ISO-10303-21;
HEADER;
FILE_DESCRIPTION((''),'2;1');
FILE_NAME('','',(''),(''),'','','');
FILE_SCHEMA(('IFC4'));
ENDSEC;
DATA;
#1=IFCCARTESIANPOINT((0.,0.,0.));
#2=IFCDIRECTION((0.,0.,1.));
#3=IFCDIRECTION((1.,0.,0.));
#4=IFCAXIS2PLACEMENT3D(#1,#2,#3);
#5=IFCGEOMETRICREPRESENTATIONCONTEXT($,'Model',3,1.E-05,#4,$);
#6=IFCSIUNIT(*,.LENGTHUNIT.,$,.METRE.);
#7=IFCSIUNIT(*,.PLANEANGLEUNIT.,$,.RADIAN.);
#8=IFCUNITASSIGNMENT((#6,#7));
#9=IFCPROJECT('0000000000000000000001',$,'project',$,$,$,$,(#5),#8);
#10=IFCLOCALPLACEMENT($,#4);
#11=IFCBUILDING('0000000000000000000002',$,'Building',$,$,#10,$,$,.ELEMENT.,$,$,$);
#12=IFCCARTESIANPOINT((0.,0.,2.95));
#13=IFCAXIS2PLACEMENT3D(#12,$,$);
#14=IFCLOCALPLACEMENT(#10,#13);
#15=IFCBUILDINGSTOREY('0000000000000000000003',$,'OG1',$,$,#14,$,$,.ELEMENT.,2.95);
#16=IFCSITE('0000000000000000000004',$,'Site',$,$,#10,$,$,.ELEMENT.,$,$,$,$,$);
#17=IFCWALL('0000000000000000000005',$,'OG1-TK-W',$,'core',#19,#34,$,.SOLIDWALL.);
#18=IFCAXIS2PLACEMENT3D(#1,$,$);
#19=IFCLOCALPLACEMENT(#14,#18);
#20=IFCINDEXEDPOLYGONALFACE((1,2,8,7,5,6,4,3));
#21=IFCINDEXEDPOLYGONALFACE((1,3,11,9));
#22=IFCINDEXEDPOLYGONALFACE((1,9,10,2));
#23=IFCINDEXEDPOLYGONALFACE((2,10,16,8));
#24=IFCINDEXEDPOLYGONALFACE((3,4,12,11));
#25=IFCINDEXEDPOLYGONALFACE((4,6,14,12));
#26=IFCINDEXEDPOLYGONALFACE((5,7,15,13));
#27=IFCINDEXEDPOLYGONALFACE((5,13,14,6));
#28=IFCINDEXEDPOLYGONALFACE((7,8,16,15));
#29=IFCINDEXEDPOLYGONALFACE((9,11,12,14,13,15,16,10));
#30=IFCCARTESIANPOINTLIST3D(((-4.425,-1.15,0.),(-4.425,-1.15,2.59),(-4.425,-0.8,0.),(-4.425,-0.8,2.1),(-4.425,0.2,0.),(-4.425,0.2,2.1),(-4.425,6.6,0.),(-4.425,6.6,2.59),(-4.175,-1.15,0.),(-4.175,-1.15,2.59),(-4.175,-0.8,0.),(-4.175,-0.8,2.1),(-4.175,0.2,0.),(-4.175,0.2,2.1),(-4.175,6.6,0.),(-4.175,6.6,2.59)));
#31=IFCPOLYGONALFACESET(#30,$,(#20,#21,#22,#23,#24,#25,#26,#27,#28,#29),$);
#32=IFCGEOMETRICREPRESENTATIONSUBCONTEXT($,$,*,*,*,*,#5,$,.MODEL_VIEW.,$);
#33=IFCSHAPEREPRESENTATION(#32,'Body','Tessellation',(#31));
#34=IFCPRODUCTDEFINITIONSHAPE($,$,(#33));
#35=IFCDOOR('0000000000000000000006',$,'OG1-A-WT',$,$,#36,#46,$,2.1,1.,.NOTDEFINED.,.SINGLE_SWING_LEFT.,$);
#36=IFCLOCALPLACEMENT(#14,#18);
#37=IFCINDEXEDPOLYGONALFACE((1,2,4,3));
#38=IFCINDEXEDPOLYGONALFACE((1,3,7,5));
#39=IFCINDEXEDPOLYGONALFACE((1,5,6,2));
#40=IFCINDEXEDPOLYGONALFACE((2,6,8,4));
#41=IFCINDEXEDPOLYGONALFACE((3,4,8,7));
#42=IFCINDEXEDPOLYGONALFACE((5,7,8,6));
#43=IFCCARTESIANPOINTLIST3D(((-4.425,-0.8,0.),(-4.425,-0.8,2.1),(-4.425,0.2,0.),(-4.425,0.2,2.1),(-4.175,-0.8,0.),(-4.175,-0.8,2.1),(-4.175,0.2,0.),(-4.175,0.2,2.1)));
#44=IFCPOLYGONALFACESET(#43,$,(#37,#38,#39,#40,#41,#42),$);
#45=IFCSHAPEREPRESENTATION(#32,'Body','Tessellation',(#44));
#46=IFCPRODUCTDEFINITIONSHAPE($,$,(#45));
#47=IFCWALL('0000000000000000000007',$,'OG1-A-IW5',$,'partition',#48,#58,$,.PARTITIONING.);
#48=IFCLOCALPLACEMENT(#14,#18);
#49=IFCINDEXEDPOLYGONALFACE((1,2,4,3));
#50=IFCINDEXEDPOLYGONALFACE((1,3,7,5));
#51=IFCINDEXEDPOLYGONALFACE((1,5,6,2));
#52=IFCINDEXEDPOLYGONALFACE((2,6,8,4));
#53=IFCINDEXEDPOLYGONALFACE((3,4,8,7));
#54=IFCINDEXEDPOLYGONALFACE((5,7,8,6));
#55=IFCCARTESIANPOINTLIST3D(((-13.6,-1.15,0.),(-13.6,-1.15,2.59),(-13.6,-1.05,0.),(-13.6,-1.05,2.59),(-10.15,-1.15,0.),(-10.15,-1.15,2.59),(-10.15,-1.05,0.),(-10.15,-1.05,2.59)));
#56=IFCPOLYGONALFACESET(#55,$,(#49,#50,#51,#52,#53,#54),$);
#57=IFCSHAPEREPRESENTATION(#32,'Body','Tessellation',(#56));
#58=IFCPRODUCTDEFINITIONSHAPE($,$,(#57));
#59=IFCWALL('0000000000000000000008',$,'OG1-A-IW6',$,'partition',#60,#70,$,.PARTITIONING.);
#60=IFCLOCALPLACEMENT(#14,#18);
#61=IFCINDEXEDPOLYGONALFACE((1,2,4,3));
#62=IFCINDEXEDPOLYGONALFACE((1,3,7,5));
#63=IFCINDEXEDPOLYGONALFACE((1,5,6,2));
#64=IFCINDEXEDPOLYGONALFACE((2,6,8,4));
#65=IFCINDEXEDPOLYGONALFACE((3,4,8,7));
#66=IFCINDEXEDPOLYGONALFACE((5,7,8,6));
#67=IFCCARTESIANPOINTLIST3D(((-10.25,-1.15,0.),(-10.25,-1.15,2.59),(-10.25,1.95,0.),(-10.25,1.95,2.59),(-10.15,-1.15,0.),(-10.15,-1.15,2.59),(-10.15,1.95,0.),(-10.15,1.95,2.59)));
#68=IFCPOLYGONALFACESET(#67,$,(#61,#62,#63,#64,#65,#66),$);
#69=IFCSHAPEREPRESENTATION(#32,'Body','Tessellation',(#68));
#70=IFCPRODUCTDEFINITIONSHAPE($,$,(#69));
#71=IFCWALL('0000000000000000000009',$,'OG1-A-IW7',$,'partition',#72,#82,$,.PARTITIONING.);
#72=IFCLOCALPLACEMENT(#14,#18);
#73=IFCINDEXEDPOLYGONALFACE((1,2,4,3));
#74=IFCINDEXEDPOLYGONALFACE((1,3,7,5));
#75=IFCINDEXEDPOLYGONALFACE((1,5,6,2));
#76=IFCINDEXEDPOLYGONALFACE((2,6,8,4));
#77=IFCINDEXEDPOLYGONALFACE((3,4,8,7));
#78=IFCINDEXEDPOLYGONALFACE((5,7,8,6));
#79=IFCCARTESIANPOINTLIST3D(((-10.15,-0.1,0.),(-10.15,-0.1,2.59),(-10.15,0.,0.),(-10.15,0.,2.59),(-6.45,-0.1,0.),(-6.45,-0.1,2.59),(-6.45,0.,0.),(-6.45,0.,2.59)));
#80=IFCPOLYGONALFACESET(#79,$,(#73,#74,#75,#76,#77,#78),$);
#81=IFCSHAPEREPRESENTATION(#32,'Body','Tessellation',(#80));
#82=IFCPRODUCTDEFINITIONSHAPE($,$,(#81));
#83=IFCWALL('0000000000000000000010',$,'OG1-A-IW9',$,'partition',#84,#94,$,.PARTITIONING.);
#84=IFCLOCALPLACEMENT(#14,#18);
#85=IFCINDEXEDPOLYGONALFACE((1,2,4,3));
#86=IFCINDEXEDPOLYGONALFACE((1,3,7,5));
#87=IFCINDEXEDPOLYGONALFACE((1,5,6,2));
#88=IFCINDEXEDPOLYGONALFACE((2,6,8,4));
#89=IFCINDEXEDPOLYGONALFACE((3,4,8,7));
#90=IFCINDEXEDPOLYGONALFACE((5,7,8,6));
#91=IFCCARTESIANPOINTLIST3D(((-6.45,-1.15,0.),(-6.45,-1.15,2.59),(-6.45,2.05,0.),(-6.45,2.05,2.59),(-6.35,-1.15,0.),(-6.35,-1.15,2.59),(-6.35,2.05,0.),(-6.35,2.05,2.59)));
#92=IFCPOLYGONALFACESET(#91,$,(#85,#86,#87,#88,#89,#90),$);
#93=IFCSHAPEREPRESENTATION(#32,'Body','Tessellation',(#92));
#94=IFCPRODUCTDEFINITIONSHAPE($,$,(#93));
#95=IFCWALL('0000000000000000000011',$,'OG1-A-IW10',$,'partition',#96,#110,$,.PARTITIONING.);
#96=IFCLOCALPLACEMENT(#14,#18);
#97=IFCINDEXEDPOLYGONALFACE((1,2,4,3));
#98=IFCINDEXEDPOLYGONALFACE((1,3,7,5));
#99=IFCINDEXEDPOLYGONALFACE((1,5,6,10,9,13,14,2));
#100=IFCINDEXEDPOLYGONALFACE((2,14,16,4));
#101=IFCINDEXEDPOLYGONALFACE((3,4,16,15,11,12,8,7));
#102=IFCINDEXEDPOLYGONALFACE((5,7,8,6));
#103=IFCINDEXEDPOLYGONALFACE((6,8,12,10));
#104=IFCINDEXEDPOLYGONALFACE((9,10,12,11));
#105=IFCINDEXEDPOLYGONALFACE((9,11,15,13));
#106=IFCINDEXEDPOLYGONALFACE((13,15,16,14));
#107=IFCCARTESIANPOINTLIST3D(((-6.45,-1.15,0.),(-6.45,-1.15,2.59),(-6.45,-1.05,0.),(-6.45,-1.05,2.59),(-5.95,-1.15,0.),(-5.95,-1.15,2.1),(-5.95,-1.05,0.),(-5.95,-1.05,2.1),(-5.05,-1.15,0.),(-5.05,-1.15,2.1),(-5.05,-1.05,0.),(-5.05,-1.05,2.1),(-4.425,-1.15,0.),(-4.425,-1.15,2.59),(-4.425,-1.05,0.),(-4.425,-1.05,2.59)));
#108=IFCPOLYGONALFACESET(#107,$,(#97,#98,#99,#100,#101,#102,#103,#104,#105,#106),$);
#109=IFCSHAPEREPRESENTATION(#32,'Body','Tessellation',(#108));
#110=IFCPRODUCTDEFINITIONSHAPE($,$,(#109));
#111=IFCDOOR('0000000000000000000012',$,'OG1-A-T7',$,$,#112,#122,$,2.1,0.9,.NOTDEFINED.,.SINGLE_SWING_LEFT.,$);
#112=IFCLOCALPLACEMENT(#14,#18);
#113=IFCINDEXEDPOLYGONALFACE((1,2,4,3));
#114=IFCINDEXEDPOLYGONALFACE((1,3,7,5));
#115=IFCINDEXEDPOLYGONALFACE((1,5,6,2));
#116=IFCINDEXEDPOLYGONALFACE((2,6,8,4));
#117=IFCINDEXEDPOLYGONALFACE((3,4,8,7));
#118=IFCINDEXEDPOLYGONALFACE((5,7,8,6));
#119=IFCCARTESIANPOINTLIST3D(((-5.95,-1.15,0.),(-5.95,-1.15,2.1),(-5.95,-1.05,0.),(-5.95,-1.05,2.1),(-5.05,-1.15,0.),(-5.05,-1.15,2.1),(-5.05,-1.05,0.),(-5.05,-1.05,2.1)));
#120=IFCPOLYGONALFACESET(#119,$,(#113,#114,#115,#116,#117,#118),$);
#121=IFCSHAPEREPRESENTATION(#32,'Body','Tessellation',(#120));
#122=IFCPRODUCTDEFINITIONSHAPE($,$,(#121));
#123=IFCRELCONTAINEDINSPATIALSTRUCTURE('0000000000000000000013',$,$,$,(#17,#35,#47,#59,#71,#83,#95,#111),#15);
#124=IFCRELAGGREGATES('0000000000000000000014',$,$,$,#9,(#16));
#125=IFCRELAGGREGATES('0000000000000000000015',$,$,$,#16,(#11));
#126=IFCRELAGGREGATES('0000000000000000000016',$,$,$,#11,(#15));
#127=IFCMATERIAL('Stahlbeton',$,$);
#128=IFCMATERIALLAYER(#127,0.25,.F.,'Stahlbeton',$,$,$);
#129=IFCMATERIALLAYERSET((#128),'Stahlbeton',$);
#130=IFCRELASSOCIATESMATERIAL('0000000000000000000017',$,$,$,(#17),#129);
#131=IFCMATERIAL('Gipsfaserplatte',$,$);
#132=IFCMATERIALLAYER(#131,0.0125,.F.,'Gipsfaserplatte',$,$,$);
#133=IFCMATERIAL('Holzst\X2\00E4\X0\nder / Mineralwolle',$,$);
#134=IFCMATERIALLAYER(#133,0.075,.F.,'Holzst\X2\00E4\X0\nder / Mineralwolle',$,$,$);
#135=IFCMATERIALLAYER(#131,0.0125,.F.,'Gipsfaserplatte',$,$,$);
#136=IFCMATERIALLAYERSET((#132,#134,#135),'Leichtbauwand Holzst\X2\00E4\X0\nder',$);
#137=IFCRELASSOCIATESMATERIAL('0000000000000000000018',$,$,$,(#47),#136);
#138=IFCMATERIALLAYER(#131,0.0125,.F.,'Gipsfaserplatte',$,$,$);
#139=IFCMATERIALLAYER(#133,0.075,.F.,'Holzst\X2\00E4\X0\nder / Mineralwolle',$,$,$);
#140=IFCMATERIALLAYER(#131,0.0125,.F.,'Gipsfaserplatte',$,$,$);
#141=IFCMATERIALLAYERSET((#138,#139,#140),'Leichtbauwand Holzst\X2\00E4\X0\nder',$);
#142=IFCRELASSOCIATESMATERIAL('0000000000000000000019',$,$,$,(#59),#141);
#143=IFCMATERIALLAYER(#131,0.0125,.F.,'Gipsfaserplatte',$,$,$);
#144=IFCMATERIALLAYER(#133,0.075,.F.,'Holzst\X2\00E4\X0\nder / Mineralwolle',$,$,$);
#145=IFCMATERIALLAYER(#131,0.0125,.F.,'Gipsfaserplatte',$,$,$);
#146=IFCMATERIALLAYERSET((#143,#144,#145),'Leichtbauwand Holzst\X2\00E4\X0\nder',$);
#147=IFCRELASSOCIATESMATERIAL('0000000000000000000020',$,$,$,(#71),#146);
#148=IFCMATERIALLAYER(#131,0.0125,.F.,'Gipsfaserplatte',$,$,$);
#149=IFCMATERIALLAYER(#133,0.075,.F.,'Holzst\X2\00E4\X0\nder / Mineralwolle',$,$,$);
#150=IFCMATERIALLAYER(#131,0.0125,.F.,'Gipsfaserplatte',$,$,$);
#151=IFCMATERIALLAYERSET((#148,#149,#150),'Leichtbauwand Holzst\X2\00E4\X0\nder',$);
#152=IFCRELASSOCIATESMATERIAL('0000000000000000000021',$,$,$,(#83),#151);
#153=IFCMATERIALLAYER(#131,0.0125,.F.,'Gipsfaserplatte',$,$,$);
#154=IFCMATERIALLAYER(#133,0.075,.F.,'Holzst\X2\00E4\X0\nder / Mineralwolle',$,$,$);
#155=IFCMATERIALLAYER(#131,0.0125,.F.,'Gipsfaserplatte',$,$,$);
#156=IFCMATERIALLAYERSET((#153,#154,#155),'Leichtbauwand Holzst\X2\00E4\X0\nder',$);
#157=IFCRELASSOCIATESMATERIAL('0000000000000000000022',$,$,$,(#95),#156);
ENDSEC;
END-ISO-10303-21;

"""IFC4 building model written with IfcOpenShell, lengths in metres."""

from ifc_helpers import new_model, si_unit, frame, frame_2d, origin, origin_with_axes, place, context, subcontext, project, spatial, rectangle, extrude, material, layer, layer_set, element, fill, save


model = new_model("IFC4")

# Units and contexts
model_context = context("Model", 3, precision=1e-05, world=origin_with_axes())
sub_context = subcontext(model_context, None, None, "MODEL_VIEW")
ifc_project = project(units=[si_unit("LENGTHUNIT", "METRE"), si_unit("PLANEANGLEUNIT", "RADIAN")], contexts=[model_context])

# Site, building, storey
placement = place(None, origin_with_axes())
site = spatial("IfcSite", under=ifc_project, at=placement, Name="Site", CompositionType="ELEMENT")
building = spatial("IfcBuilding", under=site, at=placement, Name="Building", CompositionType="ELEMENT")
storey_placement = place(placement, frame((0.0, 0.0, 2.95)))
storey = spatial("IfcBuildingStorey", under=building, at=storey_placement, Name="OG1", CompositionType="ELEMENT", Elevation=2.95)

# Shared definitions
ifc_material_1 = material(Name="Gipsfaserplatte")

# Wall, opening, door
ifc_material_2 = material(Name="Stahlbeton")
ifc_layer_1 = layer(ifc_material_2, 0.25, ventilated=False, Name="Stahlbeton")
ifc_layer_set_1 = layer_set([ifc_layer_1], Name="Stahlbeton")
wall_1_placement = place(storey_placement, frame((-4.3, -1.15, 0.0), z_axis=(0.0, 0.0, 1.0), x_axis=(0.0, 1.0, 0.0)))
wall_1 = element("IfcWall", 1, at=wall_1_placement, inside=storey, material=ifc_layer_set_1, Name="OG1-TK-W", ObjectType="core", PredefinedType="SOLIDWALL", context=sub_context, shape_type="SweptSolid", body=[
    extrude(rectangle(XDim=7.75, YDim=0.25, at=frame_2d((3.875, 0.0))), origin(), (0.0, 0.0, 1.0), 2.59),
])
opening_1_placement = place(wall_1_placement, frame((0.85, 0.175, 0.0), z_axis=(0.0, -1.0, 0.0), x_axis=(1.0, 0.0, 0.0)))
opening_1 = element("IfcOpeningElement", 2, at=opening_1_placement, cuts=wall_1, PredefinedType="OPENING", context=sub_context, shape_type="SweptSolid", body=[
    extrude(rectangle(XDim=1.0, YDim=2.1, at=frame_2d((0.0, 1.05))), origin(), (0.0, 0.0, 1.0), 0.35),
])
door_1_placement = place(wall_1_placement, frame((0.85, 0.125, 0.0), z_axis=(0.0, -1.0, 0.0), x_axis=(1.0, 0.0, 0.0)))
door_1 = element("IfcDoor", 3, at=door_1_placement, inside=storey, Name="OG1-A-WT", OperationType="SINGLE_SWING_LEFT", OverallHeight=2.1, OverallWidth=1.0, PredefinedType="NOTDEFINED", context=sub_context, shape_type="SweptSolid", body=[
    extrude(rectangle(XDim=1.0, YDim=2.1, at=frame_2d((0.0, 1.05))), origin(), (0.0, 0.0, 1.0), 0.25),
])
fill(opening_1, door_1)

# Walls
ifc_layer_2 = layer(ifc_material_1, 0.0125, ventilated=False, Name="Gipsfaserplatte")
ifc_material_3 = material(Name="Holzständer / Mineralwolle")
ifc_layer_3 = layer(ifc_material_3, 0.075, ventilated=False, Name="Holzständer / Mineralwolle")
ifc_layer_4 = layer(ifc_material_1, 0.0125, ventilated=False, Name="Gipsfaserplatte")
ifc_layer_set_2 = layer_set([ifc_layer_2, ifc_layer_3, ifc_layer_4], Name="Leichtbauwand Holzständer")
wall_2_placement = place(storey_placement, frame((-13.6, -1.1, 0.0), z_axis=(0.0, 0.0, 1.0), x_axis=(1.0, 0.0, 0.0)))
element("IfcWall", 4, at=wall_2_placement, inside=storey, material=ifc_layer_set_2, Name="OG1-A-IW5", ObjectType="partition", PredefinedType="PARTITIONING", context=sub_context, shape_type="SweptSolid", body=[
    extrude(rectangle(XDim=3.45, YDim=0.1, at=frame_2d((1.725, 0.0))), origin(), (0.0, 0.0, 1.0), 2.59),
])
ifc_layer_5 = layer(ifc_material_1, 0.0125, ventilated=False, Name="Gipsfaserplatte")
ifc_layer_6 = layer(ifc_material_3, 0.075, ventilated=False, Name="Holzständer / Mineralwolle")
ifc_layer_7 = layer(ifc_material_1, 0.0125, ventilated=False, Name="Gipsfaserplatte")
ifc_layer_set_3 = layer_set([ifc_layer_5, ifc_layer_6, ifc_layer_7], Name="Leichtbauwand Holzständer")
wall_3_placement = place(storey_placement, frame((-10.2, -1.15, 0.0), z_axis=(0.0, 0.0, 1.0), x_axis=(0.0, 1.0, 0.0)))
element("IfcWall", 5, at=wall_3_placement, inside=storey, material=ifc_layer_set_3, Name="OG1-A-IW6", ObjectType="partition", PredefinedType="PARTITIONING", context=sub_context, shape_type="SweptSolid", body=[
    extrude(rectangle(XDim=3.1, YDim=0.1, at=frame_2d((1.55, 0.0))), origin(), (0.0, 0.0, 1.0), 2.59),
])
ifc_layer_8 = layer(ifc_material_1, 0.0125, ventilated=False, Name="Gipsfaserplatte")
ifc_layer_9 = layer(ifc_material_3, 0.075, ventilated=False, Name="Holzständer / Mineralwolle")
ifc_layer_10 = layer(ifc_material_1, 0.0125, ventilated=False, Name="Gipsfaserplatte")
ifc_layer_set_4 = layer_set([ifc_layer_8, ifc_layer_9, ifc_layer_10], Name="Leichtbauwand Holzständer")
wall_4_placement = place(storey_placement, frame((-10.15, -0.05, 0.0), z_axis=(0.0, 0.0, 1.0), x_axis=(1.0, 0.0, 0.0)))
element("IfcWall", 6, at=wall_4_placement, inside=storey, material=ifc_layer_set_4, Name="OG1-A-IW7", ObjectType="partition", PredefinedType="PARTITIONING", context=sub_context, shape_type="SweptSolid", body=[
    extrude(rectangle(XDim=3.7, YDim=0.1, at=frame_2d((1.85, 0.0))), origin(), (0.0, 0.0, 1.0), 2.59),
])
ifc_layer_11 = layer(ifc_material_1, 0.0125, ventilated=False, Name="Gipsfaserplatte")
ifc_layer_12 = layer(ifc_material_3, 0.075, ventilated=False, Name="Holzständer / Mineralwolle")
ifc_layer_13 = layer(ifc_material_1, 0.0125, ventilated=False, Name="Gipsfaserplatte")
ifc_layer_set_5 = layer_set([ifc_layer_11, ifc_layer_12, ifc_layer_13], Name="Leichtbauwand Holzständer")
wall_5_placement = place(storey_placement, frame((-6.4, -1.15, 0.0), z_axis=(0.0, 0.0, 1.0), x_axis=(0.0, 1.0, 0.0)))
element("IfcWall", 7, at=wall_5_placement, inside=storey, material=ifc_layer_set_5, Name="OG1-A-IW9", ObjectType="partition", PredefinedType="PARTITIONING", context=sub_context, shape_type="SweptSolid", body=[
    extrude(rectangle(XDim=3.2, YDim=0.1, at=frame_2d((1.6, 0.0))), origin(), (0.0, 0.0, 1.0), 2.59),
])

# Wall, opening, door
ifc_layer_14 = layer(ifc_material_1, 0.0125, ventilated=False, Name="Gipsfaserplatte")
ifc_layer_15 = layer(ifc_material_3, 0.075, ventilated=False, Name="Holzständer / Mineralwolle")
ifc_layer_16 = layer(ifc_material_1, 0.0125, ventilated=False, Name="Gipsfaserplatte")
ifc_layer_set_6 = layer_set([ifc_layer_14, ifc_layer_15, ifc_layer_16], Name="Leichtbauwand Holzständer")
wall_6_placement = place(storey_placement, frame((-6.45, -1.1, 0.0), z_axis=(0.0, 0.0, 1.0), x_axis=(1.0, 0.0, 0.0)))
wall_6 = element("IfcWall", 8, at=wall_6_placement, inside=storey, material=ifc_layer_set_6, Name="OG1-A-IW10", ObjectType="partition", PredefinedType="PARTITIONING", context=sub_context, shape_type="SweptSolid", body=[
    extrude(rectangle(XDim=2.025, YDim=0.1, at=frame_2d((1.0125, 0.0))), origin(), (0.0, 0.0, 1.0), 2.59),
])
opening_2_placement = place(wall_6_placement, frame((0.95, 0.1, 0.0), z_axis=(0.0, -1.0, 0.0), x_axis=(1.0, 0.0, 0.0)))
opening_2 = element("IfcOpeningElement", 9, at=opening_2_placement, cuts=wall_6, PredefinedType="OPENING", context=sub_context, shape_type="SweptSolid", body=[
    extrude(rectangle(XDim=0.9, YDim=2.1, at=frame_2d((0.0, 1.05))), origin(), (0.0, 0.0, 1.0), 0.2),
])
door_2_placement = place(wall_6_placement, frame((0.95, 0.05, 0.0), z_axis=(0.0, -1.0, 0.0), x_axis=(1.0, 0.0, 0.0)))
door_2 = element("IfcDoor", 10, at=door_2_placement, inside=storey, Name="OG1-A-T7", OperationType="SINGLE_SWING_LEFT", OverallHeight=2.1, OverallWidth=0.9, PredefinedType="NOTDEFINED", context=sub_context, shape_type="SweptSolid", body=[
    extrude(rectangle(XDim=0.9, YDim=2.1, at=frame_2d((0.0, 1.05))), origin(), (0.0, 0.0, 1.0), 0.1),
])
fill(opening_2, door_2)

save(model, "model.ifc")
